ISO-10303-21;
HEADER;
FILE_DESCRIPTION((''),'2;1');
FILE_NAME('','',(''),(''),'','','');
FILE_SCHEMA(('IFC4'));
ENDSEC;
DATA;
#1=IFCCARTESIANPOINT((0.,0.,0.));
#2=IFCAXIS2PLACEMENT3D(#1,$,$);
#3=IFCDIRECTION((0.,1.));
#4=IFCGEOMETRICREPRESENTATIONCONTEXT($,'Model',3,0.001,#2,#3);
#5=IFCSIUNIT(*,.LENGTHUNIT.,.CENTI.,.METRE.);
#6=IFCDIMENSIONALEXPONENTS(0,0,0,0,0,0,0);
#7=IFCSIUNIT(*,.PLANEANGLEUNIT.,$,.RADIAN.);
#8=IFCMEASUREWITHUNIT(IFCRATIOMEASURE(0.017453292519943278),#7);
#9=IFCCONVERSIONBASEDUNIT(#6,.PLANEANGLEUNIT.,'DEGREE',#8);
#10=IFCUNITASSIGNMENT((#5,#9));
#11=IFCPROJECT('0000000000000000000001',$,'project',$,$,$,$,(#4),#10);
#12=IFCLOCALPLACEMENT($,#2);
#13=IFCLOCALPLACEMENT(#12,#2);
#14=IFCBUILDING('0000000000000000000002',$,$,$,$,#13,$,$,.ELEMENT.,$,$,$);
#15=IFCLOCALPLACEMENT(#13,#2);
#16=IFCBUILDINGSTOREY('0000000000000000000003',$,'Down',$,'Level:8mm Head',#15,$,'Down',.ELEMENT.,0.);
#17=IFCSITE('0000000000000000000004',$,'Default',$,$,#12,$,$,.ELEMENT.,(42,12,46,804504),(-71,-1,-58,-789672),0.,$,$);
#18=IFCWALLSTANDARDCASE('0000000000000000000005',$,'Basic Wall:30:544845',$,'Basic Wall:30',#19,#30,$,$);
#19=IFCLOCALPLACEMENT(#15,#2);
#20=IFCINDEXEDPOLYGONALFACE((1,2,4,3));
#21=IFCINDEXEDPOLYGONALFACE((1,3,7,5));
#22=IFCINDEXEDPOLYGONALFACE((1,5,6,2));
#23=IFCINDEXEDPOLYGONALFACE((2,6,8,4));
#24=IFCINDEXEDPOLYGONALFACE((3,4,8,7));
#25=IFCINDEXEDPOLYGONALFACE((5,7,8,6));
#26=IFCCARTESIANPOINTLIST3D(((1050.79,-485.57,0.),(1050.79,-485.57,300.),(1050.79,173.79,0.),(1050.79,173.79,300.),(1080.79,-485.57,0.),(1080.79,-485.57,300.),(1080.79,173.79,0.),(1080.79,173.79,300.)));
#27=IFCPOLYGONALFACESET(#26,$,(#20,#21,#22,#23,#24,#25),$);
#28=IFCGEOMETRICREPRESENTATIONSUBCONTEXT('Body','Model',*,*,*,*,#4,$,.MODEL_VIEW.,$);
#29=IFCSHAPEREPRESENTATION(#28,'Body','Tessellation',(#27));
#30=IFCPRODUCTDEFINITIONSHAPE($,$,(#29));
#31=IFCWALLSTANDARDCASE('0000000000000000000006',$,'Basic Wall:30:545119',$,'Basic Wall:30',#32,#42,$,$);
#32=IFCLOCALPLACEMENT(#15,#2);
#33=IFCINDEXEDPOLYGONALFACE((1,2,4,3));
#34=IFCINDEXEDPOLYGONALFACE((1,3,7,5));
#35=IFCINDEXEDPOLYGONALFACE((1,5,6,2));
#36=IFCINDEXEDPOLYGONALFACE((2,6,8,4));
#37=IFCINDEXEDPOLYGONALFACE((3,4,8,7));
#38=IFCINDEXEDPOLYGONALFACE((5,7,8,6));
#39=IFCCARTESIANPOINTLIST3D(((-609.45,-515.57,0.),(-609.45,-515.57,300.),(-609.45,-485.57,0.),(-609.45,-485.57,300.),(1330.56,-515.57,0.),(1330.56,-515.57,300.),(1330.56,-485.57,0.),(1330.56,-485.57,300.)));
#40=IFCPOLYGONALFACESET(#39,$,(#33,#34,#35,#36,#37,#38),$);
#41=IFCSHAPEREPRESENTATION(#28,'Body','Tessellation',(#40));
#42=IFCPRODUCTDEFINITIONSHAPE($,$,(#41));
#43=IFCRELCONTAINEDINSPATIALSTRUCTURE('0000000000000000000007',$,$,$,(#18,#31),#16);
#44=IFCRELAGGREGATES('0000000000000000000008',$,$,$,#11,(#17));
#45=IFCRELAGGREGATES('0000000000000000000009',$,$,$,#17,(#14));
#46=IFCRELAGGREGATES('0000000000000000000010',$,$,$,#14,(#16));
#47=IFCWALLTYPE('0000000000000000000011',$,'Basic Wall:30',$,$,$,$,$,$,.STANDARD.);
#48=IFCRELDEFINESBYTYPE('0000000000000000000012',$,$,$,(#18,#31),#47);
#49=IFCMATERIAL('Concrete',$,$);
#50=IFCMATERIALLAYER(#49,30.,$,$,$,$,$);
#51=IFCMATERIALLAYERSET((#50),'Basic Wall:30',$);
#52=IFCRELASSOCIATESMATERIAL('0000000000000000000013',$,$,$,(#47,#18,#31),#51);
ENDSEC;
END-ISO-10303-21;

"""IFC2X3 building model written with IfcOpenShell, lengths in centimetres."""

from ifc_helpers import new_model, entity, si_unit, converted_unit, direction, frame, frame_2d, origin, place, context, subcontext, project, spatial, rectangle, extrude, material, layer, layer_set, layer_usage, type_object, element, save


model = new_model("IFC2X3")

# Units and contexts
model_context = context("Model", 3, precision=0.001, world=origin(), true_north=direction((0.0, 1.0)))
body_context = subcontext(model_context, "Body", "Model", "MODEL_VIEW")
ifc_project = project(units=[si_unit("LENGTHUNIT", "METRE", prefix="CENTI"), converted_unit("PLANEANGLEUNIT", "DEGREE", entity("IfcRatioMeasure", 0.017453292519943278), si_unit("PLANEANGLEUNIT", "RADIAN"), dimensions=[0, 0, 0, 0, 0, 0, 0])], contexts=[model_context])

# Site, building, storey
site_placement = place(None, origin())
site = spatial("IfcSite", under=ifc_project, at=site_placement, Name="Default", CompositionType="ELEMENT", RefLatitude=(42, 12, 46, 804504), RefLongitude=(-71, -1, -58, -789672), RefElevation=0.0)
building_placement = place(site_placement, origin())
building = spatial("IfcBuilding", under=site, at=building_placement, CompositionType="ELEMENT")
storey_placement = place(building_placement, origin())
storey = spatial("IfcBuildingStorey", under=building, at=storey_placement, Name="Down", ObjectType="Level:8mm Head", LongName="Down", CompositionType="ELEMENT", Elevation=0.0)

# Shared definitions
ifc_material = material(Name="Concrete")

# Walls
ifc_layer_1 = layer(ifc_material, 30.0)
ifc_layer_set_1 = layer_set([ifc_layer_1], Name="Basic Wall:30")
wall_type_1 = type_object("IfcWallType", Name="Basic Wall:30", PredefinedType="STANDARD", material=ifc_layer_set_1)
ifc_layer_usage_1 = layer_usage(ifc_layer_set_1, "AXIS2", "NEGATIVE", 15.0)
wall_1_placement = place(storey_placement, frame((1065.79, 173.79, 0.0), z_axis=(0.0, 0.0, 1.0), x_axis=(0.0, -1.0, 0.0)))
element("IfcWallStandardCase", 1, at=wall_1_placement, inside=storey, type_object=wall_type_1, material=ifc_layer_usage_1, Name="Basic Wall:30:544845", ObjectType="Basic Wall:30", context=body_context, shape_type="SweptSolid", body=[
    extrude(rectangle(XDim=659.35, YDim=30.0, at=frame_2d((329.68, 0.0), x_axis=(-1.0, 0.0))), origin(), (0.0, 0.0, 1.0), 300.0),
])
ifc_layer_usage_2 = layer_usage(ifc_layer_set_1, "AXIS2", "POSITIVE", -15.0)
wall_2_placement = place(storey_placement, frame((1330.56, -500.57, 0.0), z_axis=(0.0, 0.0, 1.0), x_axis=(-1.0, 0.0, 0.0)))
element("IfcWallStandardCase", 2, at=wall_2_placement, inside=storey, type_object=wall_type_1, material=ifc_layer_usage_2, Name="Basic Wall:30:545119", ObjectType="Basic Wall:30", context=body_context, shape_type="SweptSolid", body=[
    extrude(rectangle(XDim=1940.01, YDim=30.0, at=frame_2d((970.01, 0.0), x_axis=(-1.0, 0.0))), origin(), (0.0, 0.0, 1.0), 300.0),
])

save(model, "model.ifc")
